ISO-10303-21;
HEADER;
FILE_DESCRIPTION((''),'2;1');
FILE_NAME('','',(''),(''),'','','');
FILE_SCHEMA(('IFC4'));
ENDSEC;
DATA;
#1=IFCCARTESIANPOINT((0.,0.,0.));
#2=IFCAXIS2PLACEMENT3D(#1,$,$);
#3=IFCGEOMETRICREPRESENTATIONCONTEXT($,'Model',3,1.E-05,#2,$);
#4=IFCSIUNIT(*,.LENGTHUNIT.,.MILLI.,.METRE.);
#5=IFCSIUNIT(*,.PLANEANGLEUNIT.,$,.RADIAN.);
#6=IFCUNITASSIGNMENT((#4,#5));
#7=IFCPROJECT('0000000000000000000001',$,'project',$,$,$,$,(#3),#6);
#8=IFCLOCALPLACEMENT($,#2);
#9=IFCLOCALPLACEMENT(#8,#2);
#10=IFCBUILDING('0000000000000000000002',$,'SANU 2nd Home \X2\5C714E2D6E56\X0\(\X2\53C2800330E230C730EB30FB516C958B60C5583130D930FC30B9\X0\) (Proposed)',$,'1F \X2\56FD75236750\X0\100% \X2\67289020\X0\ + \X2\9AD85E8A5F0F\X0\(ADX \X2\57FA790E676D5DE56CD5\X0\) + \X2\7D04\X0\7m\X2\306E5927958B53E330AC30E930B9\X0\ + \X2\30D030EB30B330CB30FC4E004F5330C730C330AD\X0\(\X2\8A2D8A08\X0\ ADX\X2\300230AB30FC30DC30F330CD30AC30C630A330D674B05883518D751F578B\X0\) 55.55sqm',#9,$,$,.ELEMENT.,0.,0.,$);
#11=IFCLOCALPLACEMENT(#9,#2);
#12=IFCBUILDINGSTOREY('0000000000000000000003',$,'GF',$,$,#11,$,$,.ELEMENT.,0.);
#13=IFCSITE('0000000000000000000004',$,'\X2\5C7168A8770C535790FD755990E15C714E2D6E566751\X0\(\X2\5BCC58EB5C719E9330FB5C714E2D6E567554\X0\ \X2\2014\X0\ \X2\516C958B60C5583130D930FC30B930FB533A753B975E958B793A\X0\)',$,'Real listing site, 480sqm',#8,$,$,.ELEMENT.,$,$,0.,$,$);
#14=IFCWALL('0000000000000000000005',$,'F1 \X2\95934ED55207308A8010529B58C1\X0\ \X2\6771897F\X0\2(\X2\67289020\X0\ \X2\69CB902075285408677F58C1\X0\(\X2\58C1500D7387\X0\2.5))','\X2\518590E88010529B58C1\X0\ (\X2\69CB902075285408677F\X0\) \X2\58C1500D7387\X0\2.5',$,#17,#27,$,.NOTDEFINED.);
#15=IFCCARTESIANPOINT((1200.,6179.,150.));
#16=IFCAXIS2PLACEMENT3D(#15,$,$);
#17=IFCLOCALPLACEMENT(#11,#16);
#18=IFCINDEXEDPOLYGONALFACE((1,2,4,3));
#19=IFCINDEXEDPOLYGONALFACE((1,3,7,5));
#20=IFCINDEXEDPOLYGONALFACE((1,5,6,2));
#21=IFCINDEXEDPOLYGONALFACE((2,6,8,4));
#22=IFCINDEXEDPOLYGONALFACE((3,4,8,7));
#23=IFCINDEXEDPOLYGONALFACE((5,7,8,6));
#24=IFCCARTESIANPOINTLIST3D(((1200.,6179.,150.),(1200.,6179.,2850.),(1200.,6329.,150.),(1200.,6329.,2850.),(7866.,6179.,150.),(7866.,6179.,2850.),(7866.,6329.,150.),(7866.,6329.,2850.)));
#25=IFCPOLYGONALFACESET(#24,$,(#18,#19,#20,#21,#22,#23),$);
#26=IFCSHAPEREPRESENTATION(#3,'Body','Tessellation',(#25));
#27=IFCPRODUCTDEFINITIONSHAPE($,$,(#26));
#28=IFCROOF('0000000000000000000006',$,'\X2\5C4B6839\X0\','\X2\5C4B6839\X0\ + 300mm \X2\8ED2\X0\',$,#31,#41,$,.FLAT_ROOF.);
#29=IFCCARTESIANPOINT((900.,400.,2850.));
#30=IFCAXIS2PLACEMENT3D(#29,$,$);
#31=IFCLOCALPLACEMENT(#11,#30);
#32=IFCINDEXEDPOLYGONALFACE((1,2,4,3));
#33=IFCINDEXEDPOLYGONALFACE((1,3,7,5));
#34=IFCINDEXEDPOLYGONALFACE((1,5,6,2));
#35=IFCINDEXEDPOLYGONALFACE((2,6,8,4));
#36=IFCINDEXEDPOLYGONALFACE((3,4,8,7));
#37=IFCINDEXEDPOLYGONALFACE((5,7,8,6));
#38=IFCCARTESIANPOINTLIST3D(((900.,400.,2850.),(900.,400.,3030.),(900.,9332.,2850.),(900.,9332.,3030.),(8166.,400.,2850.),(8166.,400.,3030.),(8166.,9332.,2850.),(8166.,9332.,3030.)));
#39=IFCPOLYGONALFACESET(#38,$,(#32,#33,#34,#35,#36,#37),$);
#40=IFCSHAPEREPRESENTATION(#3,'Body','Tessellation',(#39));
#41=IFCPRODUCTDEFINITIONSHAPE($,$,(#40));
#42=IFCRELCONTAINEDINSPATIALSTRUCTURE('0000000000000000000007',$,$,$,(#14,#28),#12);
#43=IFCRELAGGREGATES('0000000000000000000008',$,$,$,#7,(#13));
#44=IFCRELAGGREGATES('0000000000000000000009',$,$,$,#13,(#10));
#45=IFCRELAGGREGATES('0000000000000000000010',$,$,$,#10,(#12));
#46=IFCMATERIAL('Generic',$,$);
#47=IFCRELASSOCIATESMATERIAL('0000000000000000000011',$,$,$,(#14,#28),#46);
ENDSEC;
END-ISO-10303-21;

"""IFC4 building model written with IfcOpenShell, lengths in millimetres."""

from ifc_helpers import new_model, si_unit, frame, frame_2d, origin, place, context, project, spatial, rectangle, extrude, material, element, save


model = new_model("IFC4")

# Units and contexts
model_context = context("Model", 3, precision=1e-05, world=origin())
ifc_project = project(units=[si_unit("LENGTHUNIT", "METRE", prefix="MILLI"), si_unit("PLANEANGLEUNIT", "RADIAN")], contexts=[model_context])

# Site, building, storey
site_placement = place(None, origin())
site = spatial("IfcSite", under=ifc_project, at=site_placement, Name="山梨県南都留郡山中湖村(富士山麓・山中湖畔 — 公開情報ベース・区画非開示)", ObjectType="Real listing site, 480sqm", CompositionType="ELEMENT", RefElevation=0.0)
building_placement = place(site_placement, origin())
building = spatial("IfcBuilding", under=site, at=building_placement, Name="SANU 2nd Home 山中湖(参考モデル・公開情報ベース) (Proposed)", ObjectType="1F 国産材100% 木造 + 高床式(ADX 基礎杭工法) + 約7mの大開口ガラス + バルコニー一体デッキ(設計 ADX。カーボンネガティブ環境再生型) 55.55sqm", CompositionType="ELEMENT", ElevationOfRefHeight=0.0, ElevationOfTerrain=0.0)
storey_placement = place(building_placement, origin())
storey = spatial("IfcBuildingStorey", under=building, at=storey_placement, Name="GF", CompositionType="ELEMENT", Elevation=0.0)

# Shared definitions
ifc_material_1 = material(Name="Generic")

# Wall
wall_1_placement = place(storey_placement, frame((1200.0, 6179.0, 150.0)))
element("IfcWall", 1, at=wall_1_placement, inside=storey, material=ifc_material_1, Name="F1 間仕切り耐力壁 東西2(木造 構造用合板壁(壁倍率2.5))", Description="内部耐力壁 (構造用合板) 壁倍率2.5", PredefinedType="NOTDEFINED", context=model_context, shape_type="SweptSolid", body=[
    extrude(rectangle(XDim=6666.0, YDim=150.0, at=frame_2d((3333.0, 75.0))), frame((1200.0, 6179.0, 150.0)), (0.0, 0.0, 1.0), 2700.0),
])

# Roof
roof_placement = place(storey_placement, frame((900.0, 400.0, 2850.0)))
element("IfcRoof", 2, at=roof_placement, inside=storey, material=ifc_material_1, Name="屋根", Description="屋根 + 300mm 軒", PredefinedType="FLAT_ROOF", context=model_context, shape_type="SweptSolid", body=[
    extrude(rectangle(XDim=7266.0, YDim=8932.0, at=frame_2d((3633.0, 4466.0))), frame((900.0, 400.0, 2850.0)), (0.0, 0.0, 1.0), 180.0),
])

save(model, "model.ifc")
